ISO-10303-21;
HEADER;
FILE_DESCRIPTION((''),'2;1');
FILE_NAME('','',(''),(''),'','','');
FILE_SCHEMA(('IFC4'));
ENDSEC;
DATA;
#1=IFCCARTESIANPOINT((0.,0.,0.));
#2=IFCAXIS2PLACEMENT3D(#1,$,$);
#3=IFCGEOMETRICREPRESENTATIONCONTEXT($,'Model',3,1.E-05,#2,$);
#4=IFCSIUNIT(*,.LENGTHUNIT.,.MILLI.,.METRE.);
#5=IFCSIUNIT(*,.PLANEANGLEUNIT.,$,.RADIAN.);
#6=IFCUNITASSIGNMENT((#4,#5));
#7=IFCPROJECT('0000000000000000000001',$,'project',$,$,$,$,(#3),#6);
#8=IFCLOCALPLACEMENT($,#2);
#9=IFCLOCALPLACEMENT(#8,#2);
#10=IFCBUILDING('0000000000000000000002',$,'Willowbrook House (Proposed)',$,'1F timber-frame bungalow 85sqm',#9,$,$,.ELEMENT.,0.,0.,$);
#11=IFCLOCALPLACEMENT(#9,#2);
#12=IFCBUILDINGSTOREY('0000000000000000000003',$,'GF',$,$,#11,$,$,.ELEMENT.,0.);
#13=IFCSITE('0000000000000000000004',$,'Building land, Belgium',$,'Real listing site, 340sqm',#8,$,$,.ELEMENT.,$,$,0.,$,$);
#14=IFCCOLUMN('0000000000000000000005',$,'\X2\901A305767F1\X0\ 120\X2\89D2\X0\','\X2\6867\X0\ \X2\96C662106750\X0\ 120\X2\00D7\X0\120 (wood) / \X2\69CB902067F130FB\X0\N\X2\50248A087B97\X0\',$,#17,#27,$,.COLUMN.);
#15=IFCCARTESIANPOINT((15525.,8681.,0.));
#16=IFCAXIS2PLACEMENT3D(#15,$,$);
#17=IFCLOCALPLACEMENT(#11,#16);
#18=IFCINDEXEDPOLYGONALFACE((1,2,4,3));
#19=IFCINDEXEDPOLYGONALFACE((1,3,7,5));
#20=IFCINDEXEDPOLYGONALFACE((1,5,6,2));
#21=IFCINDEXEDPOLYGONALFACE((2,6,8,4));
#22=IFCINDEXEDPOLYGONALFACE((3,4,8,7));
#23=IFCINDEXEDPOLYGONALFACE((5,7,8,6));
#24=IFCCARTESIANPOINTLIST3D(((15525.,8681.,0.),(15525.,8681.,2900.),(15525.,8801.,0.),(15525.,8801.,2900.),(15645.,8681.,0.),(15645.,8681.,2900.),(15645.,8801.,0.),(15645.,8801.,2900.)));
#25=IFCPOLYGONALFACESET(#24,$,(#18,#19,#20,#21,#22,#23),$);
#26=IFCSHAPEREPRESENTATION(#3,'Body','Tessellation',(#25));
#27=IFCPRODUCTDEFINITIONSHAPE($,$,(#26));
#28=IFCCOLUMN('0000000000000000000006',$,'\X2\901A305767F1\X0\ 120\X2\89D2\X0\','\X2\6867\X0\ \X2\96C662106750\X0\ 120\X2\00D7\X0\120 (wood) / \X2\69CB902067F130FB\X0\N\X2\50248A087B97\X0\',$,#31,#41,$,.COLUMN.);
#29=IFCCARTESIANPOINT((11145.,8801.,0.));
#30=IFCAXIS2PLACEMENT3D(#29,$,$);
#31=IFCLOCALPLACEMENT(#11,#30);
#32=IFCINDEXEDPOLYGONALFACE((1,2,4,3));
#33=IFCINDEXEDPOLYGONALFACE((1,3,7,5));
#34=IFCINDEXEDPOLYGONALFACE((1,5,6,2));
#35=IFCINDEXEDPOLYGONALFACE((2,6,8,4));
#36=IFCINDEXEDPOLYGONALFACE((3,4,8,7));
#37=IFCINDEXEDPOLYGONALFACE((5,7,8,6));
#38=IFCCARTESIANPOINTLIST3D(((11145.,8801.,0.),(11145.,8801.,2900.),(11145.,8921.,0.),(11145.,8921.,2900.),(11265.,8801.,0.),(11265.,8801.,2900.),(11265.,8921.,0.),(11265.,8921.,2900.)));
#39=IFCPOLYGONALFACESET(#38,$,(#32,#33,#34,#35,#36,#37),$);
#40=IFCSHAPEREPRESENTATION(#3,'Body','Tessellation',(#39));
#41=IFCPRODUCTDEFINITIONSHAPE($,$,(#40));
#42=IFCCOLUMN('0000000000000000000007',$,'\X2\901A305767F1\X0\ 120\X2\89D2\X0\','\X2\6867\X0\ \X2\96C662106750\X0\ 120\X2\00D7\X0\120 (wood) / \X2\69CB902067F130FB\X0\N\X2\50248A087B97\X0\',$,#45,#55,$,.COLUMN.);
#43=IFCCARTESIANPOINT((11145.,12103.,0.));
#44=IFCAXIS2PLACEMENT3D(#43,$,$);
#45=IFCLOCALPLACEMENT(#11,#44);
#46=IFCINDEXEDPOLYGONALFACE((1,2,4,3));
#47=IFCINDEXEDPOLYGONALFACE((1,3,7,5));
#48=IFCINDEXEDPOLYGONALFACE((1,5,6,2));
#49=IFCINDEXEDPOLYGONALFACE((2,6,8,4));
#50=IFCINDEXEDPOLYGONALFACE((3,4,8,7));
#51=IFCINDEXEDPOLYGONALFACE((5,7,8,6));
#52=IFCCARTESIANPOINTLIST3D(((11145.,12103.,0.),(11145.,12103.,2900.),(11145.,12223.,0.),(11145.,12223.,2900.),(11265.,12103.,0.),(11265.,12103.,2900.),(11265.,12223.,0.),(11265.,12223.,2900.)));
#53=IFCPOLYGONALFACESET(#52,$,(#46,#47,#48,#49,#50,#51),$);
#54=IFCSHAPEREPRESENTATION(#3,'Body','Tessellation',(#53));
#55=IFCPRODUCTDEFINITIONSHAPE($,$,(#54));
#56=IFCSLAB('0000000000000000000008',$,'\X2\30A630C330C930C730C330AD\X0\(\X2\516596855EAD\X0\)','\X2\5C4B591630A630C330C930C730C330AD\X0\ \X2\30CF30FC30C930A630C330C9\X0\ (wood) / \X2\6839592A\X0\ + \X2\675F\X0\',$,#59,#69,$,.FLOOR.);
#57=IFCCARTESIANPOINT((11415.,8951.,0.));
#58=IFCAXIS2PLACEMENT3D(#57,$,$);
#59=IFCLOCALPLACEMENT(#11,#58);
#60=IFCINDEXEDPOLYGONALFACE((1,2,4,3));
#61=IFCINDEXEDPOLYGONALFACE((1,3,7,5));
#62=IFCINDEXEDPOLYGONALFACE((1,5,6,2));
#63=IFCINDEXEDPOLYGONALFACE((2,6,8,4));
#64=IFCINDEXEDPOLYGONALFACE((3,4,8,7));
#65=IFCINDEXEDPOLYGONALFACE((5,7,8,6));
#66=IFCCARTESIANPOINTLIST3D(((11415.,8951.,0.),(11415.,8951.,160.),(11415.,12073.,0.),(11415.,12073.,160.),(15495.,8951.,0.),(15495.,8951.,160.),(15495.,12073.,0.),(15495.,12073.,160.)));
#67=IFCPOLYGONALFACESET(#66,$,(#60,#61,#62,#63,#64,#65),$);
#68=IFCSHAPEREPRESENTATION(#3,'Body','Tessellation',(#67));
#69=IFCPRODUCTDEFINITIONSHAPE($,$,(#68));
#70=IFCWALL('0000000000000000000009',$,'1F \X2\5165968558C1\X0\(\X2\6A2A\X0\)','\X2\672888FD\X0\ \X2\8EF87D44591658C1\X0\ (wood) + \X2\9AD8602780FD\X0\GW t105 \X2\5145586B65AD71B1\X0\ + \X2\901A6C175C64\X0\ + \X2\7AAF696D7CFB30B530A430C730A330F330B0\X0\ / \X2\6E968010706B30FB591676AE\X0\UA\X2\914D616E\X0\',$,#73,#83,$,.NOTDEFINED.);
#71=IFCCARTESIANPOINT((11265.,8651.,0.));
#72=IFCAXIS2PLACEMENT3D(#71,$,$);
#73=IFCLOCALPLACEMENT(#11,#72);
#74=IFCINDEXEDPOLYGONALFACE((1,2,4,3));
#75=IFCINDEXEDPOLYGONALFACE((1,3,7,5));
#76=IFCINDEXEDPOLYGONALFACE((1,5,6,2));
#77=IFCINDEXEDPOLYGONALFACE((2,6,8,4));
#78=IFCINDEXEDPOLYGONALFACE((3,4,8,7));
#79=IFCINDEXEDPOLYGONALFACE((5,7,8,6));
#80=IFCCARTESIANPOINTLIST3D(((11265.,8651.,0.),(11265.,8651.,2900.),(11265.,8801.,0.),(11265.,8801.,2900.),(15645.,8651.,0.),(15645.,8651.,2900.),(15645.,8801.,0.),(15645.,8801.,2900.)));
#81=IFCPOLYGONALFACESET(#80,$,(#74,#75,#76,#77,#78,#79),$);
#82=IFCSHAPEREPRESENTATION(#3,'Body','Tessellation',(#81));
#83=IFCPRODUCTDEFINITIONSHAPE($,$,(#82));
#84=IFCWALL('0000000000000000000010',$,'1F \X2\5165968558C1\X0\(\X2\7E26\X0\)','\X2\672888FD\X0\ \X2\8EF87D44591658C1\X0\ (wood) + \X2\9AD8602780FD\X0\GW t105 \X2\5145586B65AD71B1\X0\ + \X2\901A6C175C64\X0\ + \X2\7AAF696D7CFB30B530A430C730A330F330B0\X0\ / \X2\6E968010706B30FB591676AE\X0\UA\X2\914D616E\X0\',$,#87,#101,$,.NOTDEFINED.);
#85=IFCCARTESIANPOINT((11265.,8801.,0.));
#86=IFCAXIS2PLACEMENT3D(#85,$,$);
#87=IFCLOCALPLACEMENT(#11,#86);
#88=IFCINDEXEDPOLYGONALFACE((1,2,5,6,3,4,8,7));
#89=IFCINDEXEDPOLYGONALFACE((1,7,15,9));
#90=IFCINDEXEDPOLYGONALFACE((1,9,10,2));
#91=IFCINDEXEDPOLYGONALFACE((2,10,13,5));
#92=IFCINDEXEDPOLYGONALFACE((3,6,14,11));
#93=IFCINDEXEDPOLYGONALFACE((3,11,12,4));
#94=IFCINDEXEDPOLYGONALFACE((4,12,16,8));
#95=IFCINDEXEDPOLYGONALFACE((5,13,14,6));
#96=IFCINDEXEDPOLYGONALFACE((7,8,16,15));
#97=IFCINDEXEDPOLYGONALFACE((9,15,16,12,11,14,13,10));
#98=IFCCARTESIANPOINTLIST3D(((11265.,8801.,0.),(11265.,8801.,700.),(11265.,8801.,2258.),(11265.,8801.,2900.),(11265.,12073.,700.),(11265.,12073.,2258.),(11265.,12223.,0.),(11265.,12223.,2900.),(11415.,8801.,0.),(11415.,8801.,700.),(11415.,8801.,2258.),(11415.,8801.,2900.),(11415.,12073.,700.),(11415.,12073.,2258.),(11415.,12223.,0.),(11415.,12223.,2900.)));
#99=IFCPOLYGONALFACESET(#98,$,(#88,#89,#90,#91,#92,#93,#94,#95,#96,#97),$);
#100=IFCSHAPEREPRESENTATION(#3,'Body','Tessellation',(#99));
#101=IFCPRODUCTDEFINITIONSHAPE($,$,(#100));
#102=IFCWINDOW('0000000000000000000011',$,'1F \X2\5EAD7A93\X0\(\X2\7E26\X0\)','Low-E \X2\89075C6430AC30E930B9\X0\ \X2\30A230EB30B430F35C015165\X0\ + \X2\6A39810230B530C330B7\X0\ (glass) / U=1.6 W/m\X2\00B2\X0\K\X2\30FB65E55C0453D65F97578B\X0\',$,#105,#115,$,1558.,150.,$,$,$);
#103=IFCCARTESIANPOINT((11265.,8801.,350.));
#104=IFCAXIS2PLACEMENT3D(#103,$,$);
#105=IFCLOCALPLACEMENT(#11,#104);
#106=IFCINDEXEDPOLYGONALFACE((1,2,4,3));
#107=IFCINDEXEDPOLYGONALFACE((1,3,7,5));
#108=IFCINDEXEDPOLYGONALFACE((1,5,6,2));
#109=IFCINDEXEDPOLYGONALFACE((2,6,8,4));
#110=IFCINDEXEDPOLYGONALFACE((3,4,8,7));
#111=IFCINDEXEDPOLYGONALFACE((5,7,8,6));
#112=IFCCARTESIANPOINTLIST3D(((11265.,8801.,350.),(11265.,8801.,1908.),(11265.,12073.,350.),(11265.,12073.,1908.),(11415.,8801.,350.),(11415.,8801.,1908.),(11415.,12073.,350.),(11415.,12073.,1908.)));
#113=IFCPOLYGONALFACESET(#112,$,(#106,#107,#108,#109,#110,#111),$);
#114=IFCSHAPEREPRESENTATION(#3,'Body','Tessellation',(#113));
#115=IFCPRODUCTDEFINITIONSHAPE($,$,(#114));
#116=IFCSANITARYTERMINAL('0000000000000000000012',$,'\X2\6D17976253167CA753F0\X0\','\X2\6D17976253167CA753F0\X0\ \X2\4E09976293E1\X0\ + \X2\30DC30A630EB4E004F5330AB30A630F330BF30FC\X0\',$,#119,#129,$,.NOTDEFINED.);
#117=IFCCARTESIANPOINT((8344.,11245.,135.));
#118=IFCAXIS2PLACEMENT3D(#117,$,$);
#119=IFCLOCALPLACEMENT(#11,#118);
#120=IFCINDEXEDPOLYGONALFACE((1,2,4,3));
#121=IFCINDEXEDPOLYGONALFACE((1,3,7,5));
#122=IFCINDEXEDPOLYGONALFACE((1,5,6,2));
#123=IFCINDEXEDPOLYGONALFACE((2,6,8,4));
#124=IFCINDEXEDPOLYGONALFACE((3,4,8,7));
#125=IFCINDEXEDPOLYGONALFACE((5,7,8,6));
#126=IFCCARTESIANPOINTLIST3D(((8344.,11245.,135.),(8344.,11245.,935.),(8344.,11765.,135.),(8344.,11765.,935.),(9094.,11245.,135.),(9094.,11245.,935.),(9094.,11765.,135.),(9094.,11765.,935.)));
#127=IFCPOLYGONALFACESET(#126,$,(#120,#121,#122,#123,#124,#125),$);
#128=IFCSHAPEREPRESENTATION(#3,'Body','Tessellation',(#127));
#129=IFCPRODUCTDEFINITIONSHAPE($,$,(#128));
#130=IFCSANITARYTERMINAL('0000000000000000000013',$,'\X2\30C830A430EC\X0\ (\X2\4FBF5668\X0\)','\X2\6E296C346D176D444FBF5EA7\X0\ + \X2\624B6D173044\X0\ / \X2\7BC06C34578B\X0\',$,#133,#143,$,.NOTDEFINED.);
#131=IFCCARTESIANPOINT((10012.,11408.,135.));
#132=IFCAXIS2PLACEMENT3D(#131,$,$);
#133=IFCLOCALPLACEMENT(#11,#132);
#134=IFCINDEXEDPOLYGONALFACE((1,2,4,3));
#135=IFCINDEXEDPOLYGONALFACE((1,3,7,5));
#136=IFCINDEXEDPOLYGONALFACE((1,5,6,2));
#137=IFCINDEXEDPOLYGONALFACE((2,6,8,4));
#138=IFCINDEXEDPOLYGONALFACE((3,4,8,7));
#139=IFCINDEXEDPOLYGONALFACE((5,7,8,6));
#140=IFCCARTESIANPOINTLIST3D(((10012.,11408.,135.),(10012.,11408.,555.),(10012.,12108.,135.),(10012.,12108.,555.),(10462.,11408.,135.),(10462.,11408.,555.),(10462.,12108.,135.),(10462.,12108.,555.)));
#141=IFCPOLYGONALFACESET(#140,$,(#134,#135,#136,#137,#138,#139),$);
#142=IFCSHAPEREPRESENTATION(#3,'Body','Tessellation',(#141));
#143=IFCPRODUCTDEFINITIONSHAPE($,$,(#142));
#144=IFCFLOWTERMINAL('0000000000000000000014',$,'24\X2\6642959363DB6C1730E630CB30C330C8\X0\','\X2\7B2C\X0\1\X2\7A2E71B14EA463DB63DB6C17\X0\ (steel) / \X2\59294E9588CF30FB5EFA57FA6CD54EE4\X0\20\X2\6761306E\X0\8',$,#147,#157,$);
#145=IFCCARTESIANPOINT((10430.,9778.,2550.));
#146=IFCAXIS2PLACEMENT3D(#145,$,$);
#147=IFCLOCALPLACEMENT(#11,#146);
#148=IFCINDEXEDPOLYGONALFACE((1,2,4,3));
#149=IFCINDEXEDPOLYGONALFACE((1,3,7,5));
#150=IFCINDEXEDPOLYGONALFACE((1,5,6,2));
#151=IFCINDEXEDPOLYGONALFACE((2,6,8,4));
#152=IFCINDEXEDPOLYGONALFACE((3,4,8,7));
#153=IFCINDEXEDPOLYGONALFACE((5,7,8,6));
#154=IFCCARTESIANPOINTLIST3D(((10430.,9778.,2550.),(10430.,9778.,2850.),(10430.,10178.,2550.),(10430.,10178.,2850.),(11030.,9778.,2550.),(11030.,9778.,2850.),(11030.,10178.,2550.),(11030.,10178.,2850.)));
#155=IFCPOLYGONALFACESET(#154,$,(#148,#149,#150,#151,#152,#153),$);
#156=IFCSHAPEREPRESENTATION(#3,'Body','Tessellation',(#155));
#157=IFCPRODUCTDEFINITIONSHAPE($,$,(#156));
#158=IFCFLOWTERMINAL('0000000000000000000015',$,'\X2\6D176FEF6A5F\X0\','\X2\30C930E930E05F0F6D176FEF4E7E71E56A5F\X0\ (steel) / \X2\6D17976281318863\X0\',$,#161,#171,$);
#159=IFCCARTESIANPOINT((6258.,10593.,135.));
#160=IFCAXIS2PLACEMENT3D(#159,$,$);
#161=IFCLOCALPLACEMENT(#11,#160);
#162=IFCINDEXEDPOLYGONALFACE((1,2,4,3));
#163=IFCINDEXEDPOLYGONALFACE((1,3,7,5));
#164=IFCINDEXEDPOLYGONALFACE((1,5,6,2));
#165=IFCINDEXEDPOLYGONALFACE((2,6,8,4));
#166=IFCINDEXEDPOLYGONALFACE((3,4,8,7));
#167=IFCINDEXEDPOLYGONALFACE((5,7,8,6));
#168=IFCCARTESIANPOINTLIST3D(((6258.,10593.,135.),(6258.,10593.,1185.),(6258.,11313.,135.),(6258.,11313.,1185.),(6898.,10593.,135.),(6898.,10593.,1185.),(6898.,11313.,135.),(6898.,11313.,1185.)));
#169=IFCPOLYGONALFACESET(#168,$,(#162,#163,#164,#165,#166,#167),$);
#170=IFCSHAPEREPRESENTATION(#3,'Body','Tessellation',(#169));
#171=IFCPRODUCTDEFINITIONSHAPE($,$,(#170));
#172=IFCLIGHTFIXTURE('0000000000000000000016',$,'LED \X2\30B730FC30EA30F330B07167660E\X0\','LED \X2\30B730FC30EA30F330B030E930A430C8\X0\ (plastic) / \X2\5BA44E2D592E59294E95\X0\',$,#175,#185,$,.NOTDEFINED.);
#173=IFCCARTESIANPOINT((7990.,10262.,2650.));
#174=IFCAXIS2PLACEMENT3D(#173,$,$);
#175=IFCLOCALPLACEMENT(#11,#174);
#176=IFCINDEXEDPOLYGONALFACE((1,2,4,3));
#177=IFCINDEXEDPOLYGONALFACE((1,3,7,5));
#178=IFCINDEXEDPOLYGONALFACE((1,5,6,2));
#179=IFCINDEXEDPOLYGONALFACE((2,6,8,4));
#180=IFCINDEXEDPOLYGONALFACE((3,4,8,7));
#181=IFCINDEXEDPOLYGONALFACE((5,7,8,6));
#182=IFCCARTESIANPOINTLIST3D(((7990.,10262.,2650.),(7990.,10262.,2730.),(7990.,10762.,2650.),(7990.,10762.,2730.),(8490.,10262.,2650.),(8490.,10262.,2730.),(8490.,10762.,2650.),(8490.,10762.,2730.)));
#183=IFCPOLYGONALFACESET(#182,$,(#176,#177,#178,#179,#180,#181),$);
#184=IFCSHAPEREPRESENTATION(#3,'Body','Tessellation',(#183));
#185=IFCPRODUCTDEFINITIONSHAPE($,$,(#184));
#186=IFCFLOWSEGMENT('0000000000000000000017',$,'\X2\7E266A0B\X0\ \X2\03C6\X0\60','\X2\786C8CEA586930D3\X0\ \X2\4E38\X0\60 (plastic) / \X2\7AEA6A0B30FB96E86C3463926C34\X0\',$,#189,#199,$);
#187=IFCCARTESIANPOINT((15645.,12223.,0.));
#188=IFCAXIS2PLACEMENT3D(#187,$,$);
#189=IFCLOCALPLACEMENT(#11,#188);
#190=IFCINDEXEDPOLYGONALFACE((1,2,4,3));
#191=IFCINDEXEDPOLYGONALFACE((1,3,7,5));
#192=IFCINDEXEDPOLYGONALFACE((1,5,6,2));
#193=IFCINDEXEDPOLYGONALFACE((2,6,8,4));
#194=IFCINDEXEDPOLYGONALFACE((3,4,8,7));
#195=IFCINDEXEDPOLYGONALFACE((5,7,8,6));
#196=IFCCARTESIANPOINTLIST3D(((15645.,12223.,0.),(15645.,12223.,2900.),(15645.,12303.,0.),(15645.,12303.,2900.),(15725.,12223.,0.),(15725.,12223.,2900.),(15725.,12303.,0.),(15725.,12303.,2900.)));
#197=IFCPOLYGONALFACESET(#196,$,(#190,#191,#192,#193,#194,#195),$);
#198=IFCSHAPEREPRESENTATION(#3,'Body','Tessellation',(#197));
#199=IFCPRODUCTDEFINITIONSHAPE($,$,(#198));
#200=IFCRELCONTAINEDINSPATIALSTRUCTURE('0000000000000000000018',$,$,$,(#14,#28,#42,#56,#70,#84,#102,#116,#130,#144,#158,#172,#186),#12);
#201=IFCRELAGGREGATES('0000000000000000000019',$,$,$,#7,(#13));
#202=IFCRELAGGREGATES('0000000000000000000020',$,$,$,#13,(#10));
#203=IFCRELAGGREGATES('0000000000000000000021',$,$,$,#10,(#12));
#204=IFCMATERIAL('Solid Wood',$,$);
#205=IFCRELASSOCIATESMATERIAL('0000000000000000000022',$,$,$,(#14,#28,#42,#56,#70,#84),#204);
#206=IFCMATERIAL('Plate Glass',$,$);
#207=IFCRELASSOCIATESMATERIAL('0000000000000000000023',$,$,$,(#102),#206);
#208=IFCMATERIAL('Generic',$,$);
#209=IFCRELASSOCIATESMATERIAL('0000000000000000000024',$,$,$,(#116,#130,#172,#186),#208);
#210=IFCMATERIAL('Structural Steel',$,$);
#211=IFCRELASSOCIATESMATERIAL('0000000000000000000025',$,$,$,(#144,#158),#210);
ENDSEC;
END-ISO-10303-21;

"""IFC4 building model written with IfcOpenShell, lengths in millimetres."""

from ifc_helpers import new_model, si_unit, frame, frame_2d, origin, place, context, project, spatial, rectangle, extrude, material, element, fill, save


model = new_model("IFC4")

# Units and contexts
model_context = context("Model", 3, precision=1e-05, world=origin())
ifc_project = project(units=[si_unit("LENGTHUNIT", "METRE", prefix="MILLI"), si_unit("PLANEANGLEUNIT", "RADIAN")], contexts=[model_context])

# Site, building, storey
site_placement = place(None, origin())
site = spatial("IfcSite", under=ifc_project, at=site_placement, Name="Building land, Belgium", ObjectType="Real listing site, 340sqm", CompositionType="ELEMENT", RefElevation=0.0)
building_placement = place(site_placement, origin())
building = spatial("IfcBuilding", under=site, at=building_placement, Name="Willowbrook House (Proposed)", ObjectType="1F timber-frame bungalow 85sqm", CompositionType="ELEMENT", ElevationOfRefHeight=0.0, ElevationOfTerrain=0.0)
storey_placement = place(building_placement, origin())
storey = spatial("IfcBuildingStorey", under=building, at=storey_placement, Name="GF", CompositionType="ELEMENT", Elevation=0.0)

# Columns
ifc_material_1 = material(Name="Solid Wood")
column_1_placement = place(storey_placement, frame((15525.0, 8681.0, 0.0)))
element("IfcColumn", 1, at=column_1_placement, inside=storey, material=ifc_material_1, Name="通し柱 120角", Description="桧 集成材 120×120 (wood) / 構造柱・N値計算", PredefinedType="COLUMN", context=model_context, shape_type="SweptSolid", body=[
    extrude(rectangle(XDim=120.0, YDim=120.0, at=frame_2d((60.0, 60.0))), frame((15525.0, 8681.0, 0.0)), (0.0, 0.0, 1.0), 2900.0),
])
column_2_placement = place(storey_placement, frame((11145.0, 8801.0, 0.0)))
element("IfcColumn", 2, at=column_2_placement, inside=storey, material=ifc_material_1, Name="通し柱 120角", Description="桧 集成材 120×120 (wood) / 構造柱・N値計算", PredefinedType="COLUMN", context=model_context, shape_type="SweptSolid", body=[
    extrude(rectangle(XDim=120.0, YDim=120.0, at=frame_2d((60.0, 60.0))), frame((11145.0, 8801.0, 0.0)), (0.0, 0.0, 1.0), 2900.0),
])
column_3_placement = place(storey_placement, frame((11145.0, 12103.0, 0.0)))
element("IfcColumn", 3, at=column_3_placement, inside=storey, material=ifc_material_1, Name="通し柱 120角", Description="桧 集成材 120×120 (wood) / 構造柱・N値計算", PredefinedType="COLUMN", context=model_context, shape_type="SweptSolid", body=[
    extrude(rectangle(XDim=120.0, YDim=120.0, at=frame_2d((60.0, 60.0))), frame((11145.0, 12103.0, 0.0)), (0.0, 0.0, 1.0), 2900.0),
])

# Slab
slab_placement = place(storey_placement, frame((11415.0, 8951.0, 0.0)))
element("IfcSlab", 4, at=slab_placement, inside=storey, material=ifc_material_1, Name="ウッドデッキ(入隅庭)", Description="屋外ウッドデッキ ハードウッド (wood) / 根太 + 束", PredefinedType="FLOOR", context=model_context, shape_type="SweptSolid", body=[
    extrude(rectangle(XDim=4080.0, YDim=3122.0, at=frame_2d((2040.0, 1561.0))), frame((11415.0, 8951.0, 0.0)), (0.0, 0.0, 1.0), 160.0),
])

# Wall
wall_1_placement = place(storey_placement, frame((11265.0, 8651.0, 0.0)))
element("IfcWall", 5, at=wall_1_placement, inside=storey, material=ifc_material_1, Name="1F 入隅壁(横)", Description="木製 軸組外壁 (wood) + 高性能GW t105 充填断熱 + 通気層 + 窯業系サイディング / 準耐火・外皮UA配慮", PredefinedType="NOTDEFINED", context=model_context, shape_type="SweptSolid", body=[
    extrude(rectangle(XDim=4380.0, YDim=150.0, at=frame_2d((2190.0, 75.0))), frame((11265.0, 8651.0, 0.0)), (0.0, 0.0, 1.0), 2900.0),
])

# Wall, opening, window
wall_2_placement = place(storey_placement, frame((11265.0, 8801.0, 0.0)))
wall_2 = element("IfcWall", 6, at=wall_2_placement, inside=storey, material=ifc_material_1, Name="1F 入隅壁(縦)", Description="木製 軸組外壁 (wood) + 高性能GW t105 充填断熱 + 通気層 + 窯業系サイディング / 準耐火・外皮UA配慮", PredefinedType="NOTDEFINED", context=model_context, shape_type="SweptSolid", body=[
    extrude(rectangle(XDim=150.0, YDim=3422.0, at=frame_2d((75.0, 1711.0))), frame((11265.0, 8801.0, 0.0)), (0.0, 0.0, 1.0), 2900.0),
])
opening_placement = place(storey_placement, frame((11265.0, 8801.0, 350.0)))
opening = element("IfcOpeningElement", 7, at=opening_placement, cuts=wall_2, PredefinedType="NOTDEFINED", context=model_context, shape_type="SweptSolid", body=[
    extrude(rectangle(XDim=150.0, YDim=3272.0, at=frame_2d((75.0, 1636.0))), frame((11265.0, 8801.0, 350.0)), (0.0, 0.0, 1.0), 1558.0),
])
ifc_material_2 = material(Name="Plate Glass")
window_placement = place(storey_placement, frame((11265.0, 8801.0, 350.0)))
window = element("IfcWindow", 8, at=window_placement, inside=storey, material=ifc_material_2, Name="1F 庭窓(縦)", Description="Low-E 複層ガラス アルゴン封入 + 樹脂サッシ (glass) / U=1.6 W/m²K・日射取得型", OverallHeight=1558.0, OverallWidth=150.0, context=model_context, shape_type="SweptSolid", body=[
    extrude(rectangle(XDim=150.0, YDim=3272.0, at=frame_2d((75.0, 1636.0))), frame((11265.0, 8801.0, 350.0)), (0.0, 0.0, 1.0), 1558.0),
])
fill(opening, window)

# Sanitary terminals
ifc_material_3 = material(Name="Generic")
sanitary_terminal_1_placement = place(storey_placement, frame((8344.0, 11245.0, 135.0)))
element("IfcSanitaryTerminal", 9, at=sanitary_terminal_1_placement, inside=storey, material=ifc_material_3, Name="洗面化粧台", Description="洗面化粧台 三面鏡 + ボウル一体カウンター", PredefinedType="NOTDEFINED", context=model_context, shape_type="SweptSolid", body=[
    extrude(rectangle(XDim=750.0, YDim=520.0, at=frame_2d((375.0, 260.0))), frame((8344.0, 11245.0, 135.0)), (0.0, 0.0, 1.0), 800.0),
])
sanitary_terminal_2_placement = place(storey_placement, frame((10012.0, 11408.0, 135.0)))
element("IfcSanitaryTerminal", 10, at=sanitary_terminal_2_placement, inside=storey, material=ifc_material_3, Name="トイレ (便器)", Description="温水洗浄便座 + 手洗い / 節水型", PredefinedType="NOTDEFINED", context=model_context, shape_type="SweptSolid", body=[
    extrude(rectangle(XDim=450.0, YDim=700.0, at=frame_2d((225.0, 350.0))), frame((10012.0, 11408.0, 135.0)), (0.0, 0.0, 1.0), 420.0),
])

# Flow terminals
ifc_material_4 = material(Name="Structural Steel")
flow_terminal_1_placement = place(storey_placement, frame((10430.0, 9778.0, 2550.0)))
element("IfcFlowTerminal", 11, at=flow_terminal_1_placement, inside=storey, material=ifc_material_4, Name="24時間換気ユニット", Description="第1種熱交換換気 (steel) / 天井裏・建基法令20条の8", context=model_context, shape_type="SweptSolid", body=[
    extrude(rectangle(XDim=600.0, YDim=400.0, at=frame_2d((300.0, 200.0))), frame((10430.0, 9778.0, 2550.0)), (0.0, 0.0, 1.0), 300.0),
])
flow_terminal_2_placement = place(storey_placement, frame((6258.0, 10593.0, 135.0)))
element("IfcFlowTerminal", 12, at=flow_terminal_2_placement, inside=storey, material=ifc_material_4, Name="洗濯機", Description="ドラム式洗濯乾燥機 (steel) / 洗面脱衣", context=model_context, shape_type="SweptSolid", body=[
    extrude(rectangle(XDim=640.0, YDim=720.0, at=frame_2d((320.0, 360.0))), frame((6258.0, 10593.0, 135.0)), (0.0, 0.0, 1.0), 1050.0),
])

# Light fixture
light_fixture_placement = place(storey_placement, frame((7990.0, 10262.0, 2650.0)))
element("IfcLightFixture", 13, at=light_fixture_placement, inside=storey, material=ifc_material_3, Name="LED シーリング照明", Description="LED シーリングライト (plastic) / 室中央天井", PredefinedType="NOTDEFINED", context=model_context, shape_type="SweptSolid", body=[
    extrude(rectangle(XDim=500.0, YDim=500.0, at=frame_2d((250.0, 250.0))), frame((7990.0, 10262.0, 2650.0)), (0.0, 0.0, 1.0), 80.0),
])

# Flow segment
flow_segment_placement = place(storey_placement, frame((15645.0, 12223.0, 0.0)))
element("IfcFlowSegment", 14, at=flow_segment_placement, inside=storey, material=ifc_material_3, Name="縦樋 φ60", Description="硬質塩ビ 丸60 (plastic) / 竪樋・雨水排水", context=model_context, shape_type="SweptSolid", body=[
    extrude(rectangle(XDim=80.0, YDim=80.0, at=frame_2d((40.0, 40.0))), frame((15645.0, 12223.0, 0.0)), (0.0, 0.0, 1.0), 2900.0),
])

save(model, "model.ifc")
